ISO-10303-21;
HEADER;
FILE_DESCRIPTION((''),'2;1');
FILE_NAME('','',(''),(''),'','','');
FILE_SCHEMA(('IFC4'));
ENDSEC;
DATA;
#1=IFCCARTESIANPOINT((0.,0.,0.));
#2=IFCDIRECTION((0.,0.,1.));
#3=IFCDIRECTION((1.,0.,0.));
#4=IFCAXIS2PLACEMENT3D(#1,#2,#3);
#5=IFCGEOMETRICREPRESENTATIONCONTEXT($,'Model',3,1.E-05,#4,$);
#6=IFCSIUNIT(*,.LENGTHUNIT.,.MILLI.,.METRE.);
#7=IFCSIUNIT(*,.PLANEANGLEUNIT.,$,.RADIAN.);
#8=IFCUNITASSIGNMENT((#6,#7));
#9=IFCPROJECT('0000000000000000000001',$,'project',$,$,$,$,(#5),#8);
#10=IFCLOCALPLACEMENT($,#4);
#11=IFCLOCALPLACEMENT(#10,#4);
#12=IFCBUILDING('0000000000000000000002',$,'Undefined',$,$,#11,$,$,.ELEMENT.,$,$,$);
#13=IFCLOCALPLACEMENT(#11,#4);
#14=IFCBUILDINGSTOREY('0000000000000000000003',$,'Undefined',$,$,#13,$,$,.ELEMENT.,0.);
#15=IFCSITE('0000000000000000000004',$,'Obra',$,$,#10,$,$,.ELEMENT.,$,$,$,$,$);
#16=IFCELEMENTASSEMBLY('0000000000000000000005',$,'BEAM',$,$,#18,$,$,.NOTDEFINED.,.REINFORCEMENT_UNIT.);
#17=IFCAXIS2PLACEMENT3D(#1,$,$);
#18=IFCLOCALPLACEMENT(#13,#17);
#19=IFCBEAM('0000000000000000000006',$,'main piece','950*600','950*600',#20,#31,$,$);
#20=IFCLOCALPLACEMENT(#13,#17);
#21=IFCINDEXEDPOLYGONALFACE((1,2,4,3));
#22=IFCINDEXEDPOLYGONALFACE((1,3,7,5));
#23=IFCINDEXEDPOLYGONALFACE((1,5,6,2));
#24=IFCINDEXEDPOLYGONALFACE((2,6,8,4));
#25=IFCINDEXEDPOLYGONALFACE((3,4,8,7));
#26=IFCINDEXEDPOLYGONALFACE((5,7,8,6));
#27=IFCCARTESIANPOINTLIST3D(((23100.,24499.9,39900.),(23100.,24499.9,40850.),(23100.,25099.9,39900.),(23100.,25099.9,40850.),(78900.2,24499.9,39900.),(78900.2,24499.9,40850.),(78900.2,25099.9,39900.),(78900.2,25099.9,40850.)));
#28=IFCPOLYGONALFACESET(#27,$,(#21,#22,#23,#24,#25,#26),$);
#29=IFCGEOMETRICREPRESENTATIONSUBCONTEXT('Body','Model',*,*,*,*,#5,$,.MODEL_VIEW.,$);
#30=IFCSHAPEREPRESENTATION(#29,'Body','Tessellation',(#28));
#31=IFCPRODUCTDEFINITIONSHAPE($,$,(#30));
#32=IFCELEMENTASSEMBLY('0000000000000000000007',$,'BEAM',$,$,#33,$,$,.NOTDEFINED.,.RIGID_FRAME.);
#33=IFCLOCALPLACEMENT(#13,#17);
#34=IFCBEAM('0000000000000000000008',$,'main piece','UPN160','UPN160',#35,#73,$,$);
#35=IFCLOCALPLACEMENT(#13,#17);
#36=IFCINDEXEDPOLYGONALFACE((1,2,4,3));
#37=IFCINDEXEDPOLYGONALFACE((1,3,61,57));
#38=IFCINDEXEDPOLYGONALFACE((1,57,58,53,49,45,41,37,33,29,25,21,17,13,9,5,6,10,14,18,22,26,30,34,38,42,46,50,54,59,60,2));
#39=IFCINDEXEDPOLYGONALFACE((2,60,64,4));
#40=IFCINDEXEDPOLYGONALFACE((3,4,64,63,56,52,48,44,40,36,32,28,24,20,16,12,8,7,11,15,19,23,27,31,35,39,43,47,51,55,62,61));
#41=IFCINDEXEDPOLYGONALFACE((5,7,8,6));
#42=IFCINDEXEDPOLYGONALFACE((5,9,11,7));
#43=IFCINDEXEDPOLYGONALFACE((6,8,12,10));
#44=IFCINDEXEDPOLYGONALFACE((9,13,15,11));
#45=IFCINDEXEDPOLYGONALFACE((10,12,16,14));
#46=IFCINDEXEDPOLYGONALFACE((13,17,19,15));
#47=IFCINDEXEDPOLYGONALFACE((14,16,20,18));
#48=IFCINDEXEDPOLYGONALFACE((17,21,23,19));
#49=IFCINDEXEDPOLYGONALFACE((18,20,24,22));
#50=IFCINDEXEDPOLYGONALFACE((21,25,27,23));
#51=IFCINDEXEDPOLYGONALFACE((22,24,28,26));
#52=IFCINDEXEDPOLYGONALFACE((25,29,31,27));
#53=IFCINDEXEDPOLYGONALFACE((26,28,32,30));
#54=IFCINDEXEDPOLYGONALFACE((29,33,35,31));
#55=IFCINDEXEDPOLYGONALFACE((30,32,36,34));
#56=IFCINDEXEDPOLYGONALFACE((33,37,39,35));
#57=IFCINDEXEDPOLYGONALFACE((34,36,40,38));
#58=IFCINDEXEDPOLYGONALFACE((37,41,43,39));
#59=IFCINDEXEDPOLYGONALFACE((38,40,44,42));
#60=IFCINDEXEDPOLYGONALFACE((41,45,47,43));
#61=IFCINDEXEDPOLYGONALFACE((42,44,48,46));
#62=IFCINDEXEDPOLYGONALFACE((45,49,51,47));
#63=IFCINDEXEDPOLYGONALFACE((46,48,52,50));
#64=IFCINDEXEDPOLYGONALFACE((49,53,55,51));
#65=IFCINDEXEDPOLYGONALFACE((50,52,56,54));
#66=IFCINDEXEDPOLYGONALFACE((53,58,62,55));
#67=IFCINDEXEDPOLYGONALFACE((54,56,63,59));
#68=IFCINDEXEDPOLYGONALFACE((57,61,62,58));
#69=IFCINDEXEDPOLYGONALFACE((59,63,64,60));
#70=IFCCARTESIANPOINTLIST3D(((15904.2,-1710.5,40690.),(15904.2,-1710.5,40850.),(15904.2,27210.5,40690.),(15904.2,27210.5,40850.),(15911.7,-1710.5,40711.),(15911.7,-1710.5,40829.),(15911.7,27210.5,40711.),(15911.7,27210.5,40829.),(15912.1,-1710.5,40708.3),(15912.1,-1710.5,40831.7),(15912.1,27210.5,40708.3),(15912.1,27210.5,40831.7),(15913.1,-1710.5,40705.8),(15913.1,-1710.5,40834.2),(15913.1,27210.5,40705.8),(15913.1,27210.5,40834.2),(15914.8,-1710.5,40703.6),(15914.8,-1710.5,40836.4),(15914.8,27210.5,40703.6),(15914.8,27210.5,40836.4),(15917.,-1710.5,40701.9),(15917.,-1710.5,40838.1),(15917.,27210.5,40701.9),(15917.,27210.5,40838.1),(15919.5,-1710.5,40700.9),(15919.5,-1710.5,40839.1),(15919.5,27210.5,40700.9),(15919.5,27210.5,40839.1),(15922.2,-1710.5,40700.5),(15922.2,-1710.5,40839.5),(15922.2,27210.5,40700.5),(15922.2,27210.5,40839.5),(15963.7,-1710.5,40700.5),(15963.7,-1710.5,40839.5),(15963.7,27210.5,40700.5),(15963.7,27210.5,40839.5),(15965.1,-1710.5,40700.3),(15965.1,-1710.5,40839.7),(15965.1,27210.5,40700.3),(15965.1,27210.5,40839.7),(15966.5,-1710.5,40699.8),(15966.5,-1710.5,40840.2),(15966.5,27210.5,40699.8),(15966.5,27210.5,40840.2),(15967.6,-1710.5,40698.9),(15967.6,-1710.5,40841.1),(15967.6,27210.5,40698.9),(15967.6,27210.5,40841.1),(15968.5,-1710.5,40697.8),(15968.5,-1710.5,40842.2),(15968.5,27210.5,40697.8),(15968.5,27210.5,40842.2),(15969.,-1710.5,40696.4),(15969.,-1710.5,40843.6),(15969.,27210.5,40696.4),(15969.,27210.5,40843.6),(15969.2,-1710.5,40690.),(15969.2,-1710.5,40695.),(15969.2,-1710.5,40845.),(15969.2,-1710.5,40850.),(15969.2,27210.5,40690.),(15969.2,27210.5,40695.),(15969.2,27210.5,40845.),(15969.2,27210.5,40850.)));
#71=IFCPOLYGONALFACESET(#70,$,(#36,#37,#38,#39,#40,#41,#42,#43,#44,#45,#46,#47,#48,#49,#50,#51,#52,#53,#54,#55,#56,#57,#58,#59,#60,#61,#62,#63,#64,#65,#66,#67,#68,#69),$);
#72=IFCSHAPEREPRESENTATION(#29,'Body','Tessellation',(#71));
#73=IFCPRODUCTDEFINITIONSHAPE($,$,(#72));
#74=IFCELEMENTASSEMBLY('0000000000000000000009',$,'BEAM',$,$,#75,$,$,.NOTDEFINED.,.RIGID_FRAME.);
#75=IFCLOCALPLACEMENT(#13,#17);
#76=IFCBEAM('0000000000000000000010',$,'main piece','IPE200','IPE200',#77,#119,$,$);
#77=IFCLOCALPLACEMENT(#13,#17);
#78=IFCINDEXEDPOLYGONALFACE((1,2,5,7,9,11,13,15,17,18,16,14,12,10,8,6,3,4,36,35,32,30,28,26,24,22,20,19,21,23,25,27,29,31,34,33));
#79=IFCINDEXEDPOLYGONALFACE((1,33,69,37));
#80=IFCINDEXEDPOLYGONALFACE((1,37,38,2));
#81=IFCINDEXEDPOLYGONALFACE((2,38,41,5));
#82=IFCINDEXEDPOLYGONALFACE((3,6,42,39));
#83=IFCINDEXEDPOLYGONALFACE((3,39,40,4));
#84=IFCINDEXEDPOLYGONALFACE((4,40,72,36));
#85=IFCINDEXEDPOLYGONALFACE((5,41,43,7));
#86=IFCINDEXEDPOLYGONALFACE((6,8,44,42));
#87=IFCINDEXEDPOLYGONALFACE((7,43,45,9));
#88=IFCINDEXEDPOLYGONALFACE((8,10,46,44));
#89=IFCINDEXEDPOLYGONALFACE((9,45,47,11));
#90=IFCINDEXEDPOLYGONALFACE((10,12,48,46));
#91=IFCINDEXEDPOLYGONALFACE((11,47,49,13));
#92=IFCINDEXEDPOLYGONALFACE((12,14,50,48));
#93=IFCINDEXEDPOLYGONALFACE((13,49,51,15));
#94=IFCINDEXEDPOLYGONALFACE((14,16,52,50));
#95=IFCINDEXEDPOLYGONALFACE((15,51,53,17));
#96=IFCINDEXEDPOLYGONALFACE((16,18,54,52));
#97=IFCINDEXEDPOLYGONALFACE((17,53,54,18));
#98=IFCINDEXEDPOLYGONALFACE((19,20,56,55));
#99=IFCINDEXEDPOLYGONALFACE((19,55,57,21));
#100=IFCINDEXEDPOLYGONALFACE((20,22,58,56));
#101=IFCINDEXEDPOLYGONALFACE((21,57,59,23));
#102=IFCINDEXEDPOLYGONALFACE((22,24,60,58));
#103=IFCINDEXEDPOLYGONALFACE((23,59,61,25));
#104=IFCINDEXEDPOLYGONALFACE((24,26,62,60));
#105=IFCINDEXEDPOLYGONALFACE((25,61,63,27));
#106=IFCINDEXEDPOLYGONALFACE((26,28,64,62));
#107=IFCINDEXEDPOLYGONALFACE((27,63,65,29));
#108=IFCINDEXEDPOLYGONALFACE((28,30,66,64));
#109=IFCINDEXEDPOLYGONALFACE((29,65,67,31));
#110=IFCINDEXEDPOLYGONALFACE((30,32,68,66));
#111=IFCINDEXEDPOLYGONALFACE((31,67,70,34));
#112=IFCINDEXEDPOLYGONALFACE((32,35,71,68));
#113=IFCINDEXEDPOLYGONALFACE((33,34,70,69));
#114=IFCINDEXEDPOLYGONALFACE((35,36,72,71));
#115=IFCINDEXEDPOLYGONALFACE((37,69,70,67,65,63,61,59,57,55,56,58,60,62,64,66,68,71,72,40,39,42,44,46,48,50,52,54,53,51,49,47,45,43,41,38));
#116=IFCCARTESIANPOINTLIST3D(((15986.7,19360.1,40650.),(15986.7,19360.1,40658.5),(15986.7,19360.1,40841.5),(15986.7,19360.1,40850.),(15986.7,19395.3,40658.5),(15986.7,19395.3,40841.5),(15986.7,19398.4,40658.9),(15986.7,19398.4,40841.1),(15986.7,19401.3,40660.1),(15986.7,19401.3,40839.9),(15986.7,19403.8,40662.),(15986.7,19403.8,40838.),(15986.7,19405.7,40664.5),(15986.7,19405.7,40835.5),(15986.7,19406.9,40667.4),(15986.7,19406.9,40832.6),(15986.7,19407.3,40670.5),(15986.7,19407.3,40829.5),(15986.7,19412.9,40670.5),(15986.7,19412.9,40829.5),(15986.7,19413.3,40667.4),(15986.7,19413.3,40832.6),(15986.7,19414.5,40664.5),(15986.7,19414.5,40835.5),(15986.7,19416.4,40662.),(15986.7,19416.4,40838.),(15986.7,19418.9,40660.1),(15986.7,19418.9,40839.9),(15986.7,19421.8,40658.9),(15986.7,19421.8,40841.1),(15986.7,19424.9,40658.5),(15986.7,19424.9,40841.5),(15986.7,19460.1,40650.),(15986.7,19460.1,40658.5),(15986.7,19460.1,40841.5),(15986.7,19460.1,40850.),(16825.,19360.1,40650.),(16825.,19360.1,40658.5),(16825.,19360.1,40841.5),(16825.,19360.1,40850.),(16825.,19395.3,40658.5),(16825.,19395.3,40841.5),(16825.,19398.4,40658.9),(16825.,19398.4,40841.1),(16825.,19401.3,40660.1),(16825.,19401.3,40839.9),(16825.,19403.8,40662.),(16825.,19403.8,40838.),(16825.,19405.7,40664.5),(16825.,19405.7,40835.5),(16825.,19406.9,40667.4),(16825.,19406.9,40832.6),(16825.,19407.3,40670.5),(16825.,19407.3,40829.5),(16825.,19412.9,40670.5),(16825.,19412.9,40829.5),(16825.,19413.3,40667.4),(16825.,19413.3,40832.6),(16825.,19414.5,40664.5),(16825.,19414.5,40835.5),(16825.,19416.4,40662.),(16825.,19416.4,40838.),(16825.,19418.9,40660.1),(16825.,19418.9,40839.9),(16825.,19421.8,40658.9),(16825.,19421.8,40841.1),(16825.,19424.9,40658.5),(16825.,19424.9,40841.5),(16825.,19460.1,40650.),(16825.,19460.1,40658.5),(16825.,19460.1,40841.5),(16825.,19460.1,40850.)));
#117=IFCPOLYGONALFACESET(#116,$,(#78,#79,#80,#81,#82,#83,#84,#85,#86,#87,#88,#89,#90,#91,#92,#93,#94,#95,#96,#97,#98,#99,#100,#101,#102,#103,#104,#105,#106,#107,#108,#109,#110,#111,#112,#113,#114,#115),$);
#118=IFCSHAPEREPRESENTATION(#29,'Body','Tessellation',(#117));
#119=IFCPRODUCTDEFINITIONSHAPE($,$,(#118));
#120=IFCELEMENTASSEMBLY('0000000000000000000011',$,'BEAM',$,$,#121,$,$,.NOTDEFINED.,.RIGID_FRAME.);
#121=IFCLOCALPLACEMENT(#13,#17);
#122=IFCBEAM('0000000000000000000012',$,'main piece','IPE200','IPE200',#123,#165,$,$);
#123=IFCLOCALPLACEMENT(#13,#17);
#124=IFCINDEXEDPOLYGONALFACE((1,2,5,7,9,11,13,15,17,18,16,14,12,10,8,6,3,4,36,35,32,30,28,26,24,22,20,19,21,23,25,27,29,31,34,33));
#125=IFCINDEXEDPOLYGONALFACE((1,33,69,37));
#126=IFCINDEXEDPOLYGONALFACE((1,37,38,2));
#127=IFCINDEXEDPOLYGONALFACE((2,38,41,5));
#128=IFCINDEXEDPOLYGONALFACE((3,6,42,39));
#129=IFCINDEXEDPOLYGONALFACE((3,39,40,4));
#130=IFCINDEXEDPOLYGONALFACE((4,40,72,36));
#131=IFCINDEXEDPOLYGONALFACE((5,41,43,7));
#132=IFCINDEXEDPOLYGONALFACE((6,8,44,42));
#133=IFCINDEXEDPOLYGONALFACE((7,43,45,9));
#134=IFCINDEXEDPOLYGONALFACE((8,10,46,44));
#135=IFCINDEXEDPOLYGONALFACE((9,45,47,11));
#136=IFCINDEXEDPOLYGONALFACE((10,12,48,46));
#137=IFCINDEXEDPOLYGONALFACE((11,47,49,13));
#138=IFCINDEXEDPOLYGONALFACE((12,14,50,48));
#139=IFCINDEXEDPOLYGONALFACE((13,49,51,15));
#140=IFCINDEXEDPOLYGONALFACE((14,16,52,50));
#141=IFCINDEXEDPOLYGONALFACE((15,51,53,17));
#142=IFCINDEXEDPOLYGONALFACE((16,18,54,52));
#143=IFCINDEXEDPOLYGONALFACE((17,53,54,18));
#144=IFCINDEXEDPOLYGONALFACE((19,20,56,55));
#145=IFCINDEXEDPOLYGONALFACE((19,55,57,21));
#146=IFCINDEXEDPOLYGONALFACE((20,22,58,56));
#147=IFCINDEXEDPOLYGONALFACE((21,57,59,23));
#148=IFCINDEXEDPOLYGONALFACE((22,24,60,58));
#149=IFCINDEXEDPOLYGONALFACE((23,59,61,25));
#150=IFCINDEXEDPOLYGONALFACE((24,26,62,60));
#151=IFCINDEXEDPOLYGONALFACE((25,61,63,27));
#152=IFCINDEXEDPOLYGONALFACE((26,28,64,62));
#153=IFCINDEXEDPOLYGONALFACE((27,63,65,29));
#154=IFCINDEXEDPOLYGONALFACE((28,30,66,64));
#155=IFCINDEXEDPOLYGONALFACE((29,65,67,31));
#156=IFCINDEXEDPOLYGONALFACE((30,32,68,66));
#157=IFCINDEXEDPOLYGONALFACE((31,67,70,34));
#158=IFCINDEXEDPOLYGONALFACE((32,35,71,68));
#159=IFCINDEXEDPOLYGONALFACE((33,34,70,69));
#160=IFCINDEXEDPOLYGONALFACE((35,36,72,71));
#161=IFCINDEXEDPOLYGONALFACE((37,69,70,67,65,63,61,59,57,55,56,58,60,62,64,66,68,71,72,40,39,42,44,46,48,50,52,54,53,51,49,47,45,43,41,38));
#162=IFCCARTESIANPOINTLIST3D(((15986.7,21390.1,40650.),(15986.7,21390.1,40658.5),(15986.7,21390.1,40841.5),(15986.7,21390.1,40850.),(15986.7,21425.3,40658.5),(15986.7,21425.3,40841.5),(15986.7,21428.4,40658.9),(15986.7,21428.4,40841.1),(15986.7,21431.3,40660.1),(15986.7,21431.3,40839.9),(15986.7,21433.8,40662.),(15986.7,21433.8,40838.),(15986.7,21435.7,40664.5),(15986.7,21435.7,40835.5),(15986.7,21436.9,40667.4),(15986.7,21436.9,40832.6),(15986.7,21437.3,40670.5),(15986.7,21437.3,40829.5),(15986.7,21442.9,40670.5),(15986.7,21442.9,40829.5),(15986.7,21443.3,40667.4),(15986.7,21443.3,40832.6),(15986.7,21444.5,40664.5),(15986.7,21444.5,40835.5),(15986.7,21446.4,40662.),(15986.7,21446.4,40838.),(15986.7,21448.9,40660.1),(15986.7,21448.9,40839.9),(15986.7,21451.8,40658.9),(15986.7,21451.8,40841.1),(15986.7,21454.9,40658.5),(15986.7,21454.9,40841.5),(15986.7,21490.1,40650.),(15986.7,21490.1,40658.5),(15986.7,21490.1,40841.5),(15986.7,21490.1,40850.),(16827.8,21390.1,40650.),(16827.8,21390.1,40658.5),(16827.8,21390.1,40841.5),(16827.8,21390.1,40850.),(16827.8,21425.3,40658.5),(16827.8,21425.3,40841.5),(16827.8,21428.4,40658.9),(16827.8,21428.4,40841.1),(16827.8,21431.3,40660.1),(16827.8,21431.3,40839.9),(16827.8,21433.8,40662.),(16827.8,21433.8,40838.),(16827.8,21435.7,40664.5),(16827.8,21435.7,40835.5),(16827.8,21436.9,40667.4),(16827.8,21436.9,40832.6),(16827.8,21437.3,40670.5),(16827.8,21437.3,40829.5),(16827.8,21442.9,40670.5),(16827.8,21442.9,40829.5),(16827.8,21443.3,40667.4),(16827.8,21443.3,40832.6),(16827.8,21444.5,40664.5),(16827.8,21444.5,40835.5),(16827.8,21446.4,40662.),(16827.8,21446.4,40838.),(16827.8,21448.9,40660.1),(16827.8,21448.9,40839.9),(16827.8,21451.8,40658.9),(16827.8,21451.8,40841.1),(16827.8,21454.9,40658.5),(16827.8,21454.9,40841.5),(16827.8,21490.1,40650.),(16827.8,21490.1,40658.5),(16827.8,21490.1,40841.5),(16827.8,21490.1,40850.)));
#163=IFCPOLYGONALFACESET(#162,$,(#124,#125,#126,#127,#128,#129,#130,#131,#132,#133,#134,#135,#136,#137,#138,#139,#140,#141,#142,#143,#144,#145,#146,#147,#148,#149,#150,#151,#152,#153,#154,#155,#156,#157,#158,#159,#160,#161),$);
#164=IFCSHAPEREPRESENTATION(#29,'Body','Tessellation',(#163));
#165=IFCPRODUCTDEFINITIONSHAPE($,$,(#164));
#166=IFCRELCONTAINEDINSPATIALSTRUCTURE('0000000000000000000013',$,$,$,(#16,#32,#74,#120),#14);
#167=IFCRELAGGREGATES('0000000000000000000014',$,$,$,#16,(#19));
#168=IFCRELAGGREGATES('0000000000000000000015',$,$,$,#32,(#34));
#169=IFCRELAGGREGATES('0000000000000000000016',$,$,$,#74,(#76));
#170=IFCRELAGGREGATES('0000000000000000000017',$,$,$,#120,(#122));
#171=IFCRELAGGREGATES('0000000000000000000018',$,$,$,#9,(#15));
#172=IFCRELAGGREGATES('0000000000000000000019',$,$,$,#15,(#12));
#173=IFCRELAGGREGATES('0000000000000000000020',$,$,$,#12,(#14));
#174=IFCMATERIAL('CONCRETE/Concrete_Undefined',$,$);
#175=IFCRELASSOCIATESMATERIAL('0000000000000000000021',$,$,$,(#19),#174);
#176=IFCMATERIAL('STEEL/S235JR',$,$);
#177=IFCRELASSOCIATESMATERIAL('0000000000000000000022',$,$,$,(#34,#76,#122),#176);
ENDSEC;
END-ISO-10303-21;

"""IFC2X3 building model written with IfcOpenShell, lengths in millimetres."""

from ifc_helpers import new_model, si_unit, frame, origin_with_axes, origin_2d_with_axis, place, context, subcontext, project, spatial, rectangle, i_section, u_section, extrude, material, element, aggregate, save


model = new_model("IFC2X3")

# Units and contexts
model_context = context("Model", 3, precision=1e-05, world=origin_with_axes())
body_context = subcontext(model_context, "Body", "Model", "MODEL_VIEW")
ifc_project = project(units=[si_unit("LENGTHUNIT", "METRE", prefix="MILLI"), si_unit("PLANEANGLEUNIT", "RADIAN")], contexts=[model_context])

# Site, building, storey
site_placement = place(None, origin_with_axes())
site = spatial("IfcSite", under=ifc_project, at=site_placement, Name="Obra", CompositionType="ELEMENT")
building_placement = place(site_placement, origin_with_axes())
building = spatial("IfcBuilding", under=site, at=building_placement, Name="Undefined", CompositionType="ELEMENT")
storey_placement = place(building_placement, origin_with_axes())
storey = spatial("IfcBuildingStorey", under=building, at=storey_placement, Name="Undefined", CompositionType="ELEMENT", Elevation=0.0)

# Shared definitions
ifc_material_1 = material(Name="STEEL/S235JR")

# Element assemblies, beams
ifc_material_2 = material(Name="CONCRETE/Concrete_Undefined")
assembly_1_placement = place(storey_placement, origin_with_axes())
assembly_1 = element("IfcElementAssembly", 1, at=assembly_1_placement, inside=storey, Name="BEAM", AssemblyPlace="NOTDEFINED", PredefinedType="REINFORCEMENT_UNIT")
beam_1_placement = place(assembly_1_placement, frame((23100.0, 24799.9, 40375.0), z_axis=(0.0, 0.0, 1.0), x_axis=(1.0, 0.0, 0.0)))
beam_1 = element("IfcBeam", 2, at=beam_1_placement, material=ifc_material_2, Name="main piece", Description="950*600", ObjectType="950*600", context=body_context, shape_type="SweptSolid", body=[
    extrude(rectangle(XDim=600.0, YDim=950.0, at=origin_2d_with_axis()), frame((55800.2, 0.0, 0.0), z_axis=(-1.0, 0.0, 0.0), x_axis=(0.0, -1.0, 0.0)), (0.0, 0.0, 1.0), 55800.2),
])
aggregate(assembly_1, [beam_1])
assembly_2_placement = place(storey_placement, origin_with_axes())
assembly_2 = element("IfcElementAssembly", 3, at=assembly_2_placement, inside=storey, Name="BEAM", AssemblyPlace="NOTDEFINED", PredefinedType="RIGID_FRAME")
beam_2_placement = place(assembly_2_placement, frame((15936.7, 27210.5, 40770.0), z_axis=(0.0, 0.0, -1.0), x_axis=(0.0, -1.0, 0.0)))
beam_2 = element("IfcBeam", 4, at=beam_2_placement, material=ifc_material_1, Name="main piece", Description="UPN160", ObjectType="UPN160", context=body_context, shape_type="SweptSolid", body=[
    extrude(u_section(Depth=160.0, FlangeWidth=65.0, WebThickness=7.5, FlangeThickness=10.5, FilletRadius=10.5, EdgeRadius=5.5, at=origin_2d_with_axis()), frame((28921.0, 0.0, 0.0), z_axis=(-1.0, 0.0, 0.0), x_axis=(0.0, -1.0, 0.0)), (0.0, 0.0, 1.0), 28921.0),
])
aggregate(assembly_2, [beam_2])
assembly_3_placement = place(storey_placement, origin_with_axes())
assembly_3 = element("IfcElementAssembly", 5, at=assembly_3_placement, inside=storey, Name="BEAM", AssemblyPlace="NOTDEFINED", PredefinedType="RIGID_FRAME")
beam_3_placement = place(assembly_3_placement, frame((15986.7, 19410.1, 40750.0), z_axis=(0.0, 0.0, 1.0), x_axis=(1.0, 0.0, 0.0)))
beam_3 = element("IfcBeam", 6, at=beam_3_placement, material=ifc_material_1, Name="main piece", Description="IPE200", ObjectType="IPE200", context=body_context, shape_type="SweptSolid", body=[
    extrude(i_section(OverallWidth=100.0, OverallDepth=200.0, WebThickness=5.6, FlangeThickness=8.5, FilletRadius=12.0, at=origin_2d_with_axis()), frame((838.3, 0.0, 0.0), z_axis=(-1.0, 0.0, 0.0), x_axis=(0.0, -1.0, 0.0)), (0.0, 0.0, 1.0), 838.3),
])
aggregate(assembly_3, [beam_3])
assembly_4_placement = place(storey_placement, origin_with_axes())
assembly_4 = element("IfcElementAssembly", 7, at=assembly_4_placement, inside=storey, Name="BEAM", AssemblyPlace="NOTDEFINED", PredefinedType="RIGID_FRAME")
beam_4_placement = place(assembly_4_placement, frame((16827.8, 21440.1, 40750.0), z_axis=(0.0, 0.0, 1.0), x_axis=(-1.0, -0.00004, 0.0)))
beam_4 = element("IfcBeam", 8, at=beam_4_placement, material=ifc_material_1, Name="main piece", Description="IPE200", ObjectType="IPE200", context=body_context, shape_type="SweptSolid", body=[
    extrude(i_section(OverallWidth=100.0, OverallDepth=200.0, WebThickness=5.6, FlangeThickness=8.5, FilletRadius=12.0, at=origin_2d_with_axis()), frame((841.1, 0.0, 0.0), z_axis=(-1.0, 0.0, 0.0), x_axis=(0.0, -1.0, 0.0)), (0.0, 0.0, 1.0), 841.1),
])
aggregate(assembly_4, [beam_4])

save(model, "model.ifc")
